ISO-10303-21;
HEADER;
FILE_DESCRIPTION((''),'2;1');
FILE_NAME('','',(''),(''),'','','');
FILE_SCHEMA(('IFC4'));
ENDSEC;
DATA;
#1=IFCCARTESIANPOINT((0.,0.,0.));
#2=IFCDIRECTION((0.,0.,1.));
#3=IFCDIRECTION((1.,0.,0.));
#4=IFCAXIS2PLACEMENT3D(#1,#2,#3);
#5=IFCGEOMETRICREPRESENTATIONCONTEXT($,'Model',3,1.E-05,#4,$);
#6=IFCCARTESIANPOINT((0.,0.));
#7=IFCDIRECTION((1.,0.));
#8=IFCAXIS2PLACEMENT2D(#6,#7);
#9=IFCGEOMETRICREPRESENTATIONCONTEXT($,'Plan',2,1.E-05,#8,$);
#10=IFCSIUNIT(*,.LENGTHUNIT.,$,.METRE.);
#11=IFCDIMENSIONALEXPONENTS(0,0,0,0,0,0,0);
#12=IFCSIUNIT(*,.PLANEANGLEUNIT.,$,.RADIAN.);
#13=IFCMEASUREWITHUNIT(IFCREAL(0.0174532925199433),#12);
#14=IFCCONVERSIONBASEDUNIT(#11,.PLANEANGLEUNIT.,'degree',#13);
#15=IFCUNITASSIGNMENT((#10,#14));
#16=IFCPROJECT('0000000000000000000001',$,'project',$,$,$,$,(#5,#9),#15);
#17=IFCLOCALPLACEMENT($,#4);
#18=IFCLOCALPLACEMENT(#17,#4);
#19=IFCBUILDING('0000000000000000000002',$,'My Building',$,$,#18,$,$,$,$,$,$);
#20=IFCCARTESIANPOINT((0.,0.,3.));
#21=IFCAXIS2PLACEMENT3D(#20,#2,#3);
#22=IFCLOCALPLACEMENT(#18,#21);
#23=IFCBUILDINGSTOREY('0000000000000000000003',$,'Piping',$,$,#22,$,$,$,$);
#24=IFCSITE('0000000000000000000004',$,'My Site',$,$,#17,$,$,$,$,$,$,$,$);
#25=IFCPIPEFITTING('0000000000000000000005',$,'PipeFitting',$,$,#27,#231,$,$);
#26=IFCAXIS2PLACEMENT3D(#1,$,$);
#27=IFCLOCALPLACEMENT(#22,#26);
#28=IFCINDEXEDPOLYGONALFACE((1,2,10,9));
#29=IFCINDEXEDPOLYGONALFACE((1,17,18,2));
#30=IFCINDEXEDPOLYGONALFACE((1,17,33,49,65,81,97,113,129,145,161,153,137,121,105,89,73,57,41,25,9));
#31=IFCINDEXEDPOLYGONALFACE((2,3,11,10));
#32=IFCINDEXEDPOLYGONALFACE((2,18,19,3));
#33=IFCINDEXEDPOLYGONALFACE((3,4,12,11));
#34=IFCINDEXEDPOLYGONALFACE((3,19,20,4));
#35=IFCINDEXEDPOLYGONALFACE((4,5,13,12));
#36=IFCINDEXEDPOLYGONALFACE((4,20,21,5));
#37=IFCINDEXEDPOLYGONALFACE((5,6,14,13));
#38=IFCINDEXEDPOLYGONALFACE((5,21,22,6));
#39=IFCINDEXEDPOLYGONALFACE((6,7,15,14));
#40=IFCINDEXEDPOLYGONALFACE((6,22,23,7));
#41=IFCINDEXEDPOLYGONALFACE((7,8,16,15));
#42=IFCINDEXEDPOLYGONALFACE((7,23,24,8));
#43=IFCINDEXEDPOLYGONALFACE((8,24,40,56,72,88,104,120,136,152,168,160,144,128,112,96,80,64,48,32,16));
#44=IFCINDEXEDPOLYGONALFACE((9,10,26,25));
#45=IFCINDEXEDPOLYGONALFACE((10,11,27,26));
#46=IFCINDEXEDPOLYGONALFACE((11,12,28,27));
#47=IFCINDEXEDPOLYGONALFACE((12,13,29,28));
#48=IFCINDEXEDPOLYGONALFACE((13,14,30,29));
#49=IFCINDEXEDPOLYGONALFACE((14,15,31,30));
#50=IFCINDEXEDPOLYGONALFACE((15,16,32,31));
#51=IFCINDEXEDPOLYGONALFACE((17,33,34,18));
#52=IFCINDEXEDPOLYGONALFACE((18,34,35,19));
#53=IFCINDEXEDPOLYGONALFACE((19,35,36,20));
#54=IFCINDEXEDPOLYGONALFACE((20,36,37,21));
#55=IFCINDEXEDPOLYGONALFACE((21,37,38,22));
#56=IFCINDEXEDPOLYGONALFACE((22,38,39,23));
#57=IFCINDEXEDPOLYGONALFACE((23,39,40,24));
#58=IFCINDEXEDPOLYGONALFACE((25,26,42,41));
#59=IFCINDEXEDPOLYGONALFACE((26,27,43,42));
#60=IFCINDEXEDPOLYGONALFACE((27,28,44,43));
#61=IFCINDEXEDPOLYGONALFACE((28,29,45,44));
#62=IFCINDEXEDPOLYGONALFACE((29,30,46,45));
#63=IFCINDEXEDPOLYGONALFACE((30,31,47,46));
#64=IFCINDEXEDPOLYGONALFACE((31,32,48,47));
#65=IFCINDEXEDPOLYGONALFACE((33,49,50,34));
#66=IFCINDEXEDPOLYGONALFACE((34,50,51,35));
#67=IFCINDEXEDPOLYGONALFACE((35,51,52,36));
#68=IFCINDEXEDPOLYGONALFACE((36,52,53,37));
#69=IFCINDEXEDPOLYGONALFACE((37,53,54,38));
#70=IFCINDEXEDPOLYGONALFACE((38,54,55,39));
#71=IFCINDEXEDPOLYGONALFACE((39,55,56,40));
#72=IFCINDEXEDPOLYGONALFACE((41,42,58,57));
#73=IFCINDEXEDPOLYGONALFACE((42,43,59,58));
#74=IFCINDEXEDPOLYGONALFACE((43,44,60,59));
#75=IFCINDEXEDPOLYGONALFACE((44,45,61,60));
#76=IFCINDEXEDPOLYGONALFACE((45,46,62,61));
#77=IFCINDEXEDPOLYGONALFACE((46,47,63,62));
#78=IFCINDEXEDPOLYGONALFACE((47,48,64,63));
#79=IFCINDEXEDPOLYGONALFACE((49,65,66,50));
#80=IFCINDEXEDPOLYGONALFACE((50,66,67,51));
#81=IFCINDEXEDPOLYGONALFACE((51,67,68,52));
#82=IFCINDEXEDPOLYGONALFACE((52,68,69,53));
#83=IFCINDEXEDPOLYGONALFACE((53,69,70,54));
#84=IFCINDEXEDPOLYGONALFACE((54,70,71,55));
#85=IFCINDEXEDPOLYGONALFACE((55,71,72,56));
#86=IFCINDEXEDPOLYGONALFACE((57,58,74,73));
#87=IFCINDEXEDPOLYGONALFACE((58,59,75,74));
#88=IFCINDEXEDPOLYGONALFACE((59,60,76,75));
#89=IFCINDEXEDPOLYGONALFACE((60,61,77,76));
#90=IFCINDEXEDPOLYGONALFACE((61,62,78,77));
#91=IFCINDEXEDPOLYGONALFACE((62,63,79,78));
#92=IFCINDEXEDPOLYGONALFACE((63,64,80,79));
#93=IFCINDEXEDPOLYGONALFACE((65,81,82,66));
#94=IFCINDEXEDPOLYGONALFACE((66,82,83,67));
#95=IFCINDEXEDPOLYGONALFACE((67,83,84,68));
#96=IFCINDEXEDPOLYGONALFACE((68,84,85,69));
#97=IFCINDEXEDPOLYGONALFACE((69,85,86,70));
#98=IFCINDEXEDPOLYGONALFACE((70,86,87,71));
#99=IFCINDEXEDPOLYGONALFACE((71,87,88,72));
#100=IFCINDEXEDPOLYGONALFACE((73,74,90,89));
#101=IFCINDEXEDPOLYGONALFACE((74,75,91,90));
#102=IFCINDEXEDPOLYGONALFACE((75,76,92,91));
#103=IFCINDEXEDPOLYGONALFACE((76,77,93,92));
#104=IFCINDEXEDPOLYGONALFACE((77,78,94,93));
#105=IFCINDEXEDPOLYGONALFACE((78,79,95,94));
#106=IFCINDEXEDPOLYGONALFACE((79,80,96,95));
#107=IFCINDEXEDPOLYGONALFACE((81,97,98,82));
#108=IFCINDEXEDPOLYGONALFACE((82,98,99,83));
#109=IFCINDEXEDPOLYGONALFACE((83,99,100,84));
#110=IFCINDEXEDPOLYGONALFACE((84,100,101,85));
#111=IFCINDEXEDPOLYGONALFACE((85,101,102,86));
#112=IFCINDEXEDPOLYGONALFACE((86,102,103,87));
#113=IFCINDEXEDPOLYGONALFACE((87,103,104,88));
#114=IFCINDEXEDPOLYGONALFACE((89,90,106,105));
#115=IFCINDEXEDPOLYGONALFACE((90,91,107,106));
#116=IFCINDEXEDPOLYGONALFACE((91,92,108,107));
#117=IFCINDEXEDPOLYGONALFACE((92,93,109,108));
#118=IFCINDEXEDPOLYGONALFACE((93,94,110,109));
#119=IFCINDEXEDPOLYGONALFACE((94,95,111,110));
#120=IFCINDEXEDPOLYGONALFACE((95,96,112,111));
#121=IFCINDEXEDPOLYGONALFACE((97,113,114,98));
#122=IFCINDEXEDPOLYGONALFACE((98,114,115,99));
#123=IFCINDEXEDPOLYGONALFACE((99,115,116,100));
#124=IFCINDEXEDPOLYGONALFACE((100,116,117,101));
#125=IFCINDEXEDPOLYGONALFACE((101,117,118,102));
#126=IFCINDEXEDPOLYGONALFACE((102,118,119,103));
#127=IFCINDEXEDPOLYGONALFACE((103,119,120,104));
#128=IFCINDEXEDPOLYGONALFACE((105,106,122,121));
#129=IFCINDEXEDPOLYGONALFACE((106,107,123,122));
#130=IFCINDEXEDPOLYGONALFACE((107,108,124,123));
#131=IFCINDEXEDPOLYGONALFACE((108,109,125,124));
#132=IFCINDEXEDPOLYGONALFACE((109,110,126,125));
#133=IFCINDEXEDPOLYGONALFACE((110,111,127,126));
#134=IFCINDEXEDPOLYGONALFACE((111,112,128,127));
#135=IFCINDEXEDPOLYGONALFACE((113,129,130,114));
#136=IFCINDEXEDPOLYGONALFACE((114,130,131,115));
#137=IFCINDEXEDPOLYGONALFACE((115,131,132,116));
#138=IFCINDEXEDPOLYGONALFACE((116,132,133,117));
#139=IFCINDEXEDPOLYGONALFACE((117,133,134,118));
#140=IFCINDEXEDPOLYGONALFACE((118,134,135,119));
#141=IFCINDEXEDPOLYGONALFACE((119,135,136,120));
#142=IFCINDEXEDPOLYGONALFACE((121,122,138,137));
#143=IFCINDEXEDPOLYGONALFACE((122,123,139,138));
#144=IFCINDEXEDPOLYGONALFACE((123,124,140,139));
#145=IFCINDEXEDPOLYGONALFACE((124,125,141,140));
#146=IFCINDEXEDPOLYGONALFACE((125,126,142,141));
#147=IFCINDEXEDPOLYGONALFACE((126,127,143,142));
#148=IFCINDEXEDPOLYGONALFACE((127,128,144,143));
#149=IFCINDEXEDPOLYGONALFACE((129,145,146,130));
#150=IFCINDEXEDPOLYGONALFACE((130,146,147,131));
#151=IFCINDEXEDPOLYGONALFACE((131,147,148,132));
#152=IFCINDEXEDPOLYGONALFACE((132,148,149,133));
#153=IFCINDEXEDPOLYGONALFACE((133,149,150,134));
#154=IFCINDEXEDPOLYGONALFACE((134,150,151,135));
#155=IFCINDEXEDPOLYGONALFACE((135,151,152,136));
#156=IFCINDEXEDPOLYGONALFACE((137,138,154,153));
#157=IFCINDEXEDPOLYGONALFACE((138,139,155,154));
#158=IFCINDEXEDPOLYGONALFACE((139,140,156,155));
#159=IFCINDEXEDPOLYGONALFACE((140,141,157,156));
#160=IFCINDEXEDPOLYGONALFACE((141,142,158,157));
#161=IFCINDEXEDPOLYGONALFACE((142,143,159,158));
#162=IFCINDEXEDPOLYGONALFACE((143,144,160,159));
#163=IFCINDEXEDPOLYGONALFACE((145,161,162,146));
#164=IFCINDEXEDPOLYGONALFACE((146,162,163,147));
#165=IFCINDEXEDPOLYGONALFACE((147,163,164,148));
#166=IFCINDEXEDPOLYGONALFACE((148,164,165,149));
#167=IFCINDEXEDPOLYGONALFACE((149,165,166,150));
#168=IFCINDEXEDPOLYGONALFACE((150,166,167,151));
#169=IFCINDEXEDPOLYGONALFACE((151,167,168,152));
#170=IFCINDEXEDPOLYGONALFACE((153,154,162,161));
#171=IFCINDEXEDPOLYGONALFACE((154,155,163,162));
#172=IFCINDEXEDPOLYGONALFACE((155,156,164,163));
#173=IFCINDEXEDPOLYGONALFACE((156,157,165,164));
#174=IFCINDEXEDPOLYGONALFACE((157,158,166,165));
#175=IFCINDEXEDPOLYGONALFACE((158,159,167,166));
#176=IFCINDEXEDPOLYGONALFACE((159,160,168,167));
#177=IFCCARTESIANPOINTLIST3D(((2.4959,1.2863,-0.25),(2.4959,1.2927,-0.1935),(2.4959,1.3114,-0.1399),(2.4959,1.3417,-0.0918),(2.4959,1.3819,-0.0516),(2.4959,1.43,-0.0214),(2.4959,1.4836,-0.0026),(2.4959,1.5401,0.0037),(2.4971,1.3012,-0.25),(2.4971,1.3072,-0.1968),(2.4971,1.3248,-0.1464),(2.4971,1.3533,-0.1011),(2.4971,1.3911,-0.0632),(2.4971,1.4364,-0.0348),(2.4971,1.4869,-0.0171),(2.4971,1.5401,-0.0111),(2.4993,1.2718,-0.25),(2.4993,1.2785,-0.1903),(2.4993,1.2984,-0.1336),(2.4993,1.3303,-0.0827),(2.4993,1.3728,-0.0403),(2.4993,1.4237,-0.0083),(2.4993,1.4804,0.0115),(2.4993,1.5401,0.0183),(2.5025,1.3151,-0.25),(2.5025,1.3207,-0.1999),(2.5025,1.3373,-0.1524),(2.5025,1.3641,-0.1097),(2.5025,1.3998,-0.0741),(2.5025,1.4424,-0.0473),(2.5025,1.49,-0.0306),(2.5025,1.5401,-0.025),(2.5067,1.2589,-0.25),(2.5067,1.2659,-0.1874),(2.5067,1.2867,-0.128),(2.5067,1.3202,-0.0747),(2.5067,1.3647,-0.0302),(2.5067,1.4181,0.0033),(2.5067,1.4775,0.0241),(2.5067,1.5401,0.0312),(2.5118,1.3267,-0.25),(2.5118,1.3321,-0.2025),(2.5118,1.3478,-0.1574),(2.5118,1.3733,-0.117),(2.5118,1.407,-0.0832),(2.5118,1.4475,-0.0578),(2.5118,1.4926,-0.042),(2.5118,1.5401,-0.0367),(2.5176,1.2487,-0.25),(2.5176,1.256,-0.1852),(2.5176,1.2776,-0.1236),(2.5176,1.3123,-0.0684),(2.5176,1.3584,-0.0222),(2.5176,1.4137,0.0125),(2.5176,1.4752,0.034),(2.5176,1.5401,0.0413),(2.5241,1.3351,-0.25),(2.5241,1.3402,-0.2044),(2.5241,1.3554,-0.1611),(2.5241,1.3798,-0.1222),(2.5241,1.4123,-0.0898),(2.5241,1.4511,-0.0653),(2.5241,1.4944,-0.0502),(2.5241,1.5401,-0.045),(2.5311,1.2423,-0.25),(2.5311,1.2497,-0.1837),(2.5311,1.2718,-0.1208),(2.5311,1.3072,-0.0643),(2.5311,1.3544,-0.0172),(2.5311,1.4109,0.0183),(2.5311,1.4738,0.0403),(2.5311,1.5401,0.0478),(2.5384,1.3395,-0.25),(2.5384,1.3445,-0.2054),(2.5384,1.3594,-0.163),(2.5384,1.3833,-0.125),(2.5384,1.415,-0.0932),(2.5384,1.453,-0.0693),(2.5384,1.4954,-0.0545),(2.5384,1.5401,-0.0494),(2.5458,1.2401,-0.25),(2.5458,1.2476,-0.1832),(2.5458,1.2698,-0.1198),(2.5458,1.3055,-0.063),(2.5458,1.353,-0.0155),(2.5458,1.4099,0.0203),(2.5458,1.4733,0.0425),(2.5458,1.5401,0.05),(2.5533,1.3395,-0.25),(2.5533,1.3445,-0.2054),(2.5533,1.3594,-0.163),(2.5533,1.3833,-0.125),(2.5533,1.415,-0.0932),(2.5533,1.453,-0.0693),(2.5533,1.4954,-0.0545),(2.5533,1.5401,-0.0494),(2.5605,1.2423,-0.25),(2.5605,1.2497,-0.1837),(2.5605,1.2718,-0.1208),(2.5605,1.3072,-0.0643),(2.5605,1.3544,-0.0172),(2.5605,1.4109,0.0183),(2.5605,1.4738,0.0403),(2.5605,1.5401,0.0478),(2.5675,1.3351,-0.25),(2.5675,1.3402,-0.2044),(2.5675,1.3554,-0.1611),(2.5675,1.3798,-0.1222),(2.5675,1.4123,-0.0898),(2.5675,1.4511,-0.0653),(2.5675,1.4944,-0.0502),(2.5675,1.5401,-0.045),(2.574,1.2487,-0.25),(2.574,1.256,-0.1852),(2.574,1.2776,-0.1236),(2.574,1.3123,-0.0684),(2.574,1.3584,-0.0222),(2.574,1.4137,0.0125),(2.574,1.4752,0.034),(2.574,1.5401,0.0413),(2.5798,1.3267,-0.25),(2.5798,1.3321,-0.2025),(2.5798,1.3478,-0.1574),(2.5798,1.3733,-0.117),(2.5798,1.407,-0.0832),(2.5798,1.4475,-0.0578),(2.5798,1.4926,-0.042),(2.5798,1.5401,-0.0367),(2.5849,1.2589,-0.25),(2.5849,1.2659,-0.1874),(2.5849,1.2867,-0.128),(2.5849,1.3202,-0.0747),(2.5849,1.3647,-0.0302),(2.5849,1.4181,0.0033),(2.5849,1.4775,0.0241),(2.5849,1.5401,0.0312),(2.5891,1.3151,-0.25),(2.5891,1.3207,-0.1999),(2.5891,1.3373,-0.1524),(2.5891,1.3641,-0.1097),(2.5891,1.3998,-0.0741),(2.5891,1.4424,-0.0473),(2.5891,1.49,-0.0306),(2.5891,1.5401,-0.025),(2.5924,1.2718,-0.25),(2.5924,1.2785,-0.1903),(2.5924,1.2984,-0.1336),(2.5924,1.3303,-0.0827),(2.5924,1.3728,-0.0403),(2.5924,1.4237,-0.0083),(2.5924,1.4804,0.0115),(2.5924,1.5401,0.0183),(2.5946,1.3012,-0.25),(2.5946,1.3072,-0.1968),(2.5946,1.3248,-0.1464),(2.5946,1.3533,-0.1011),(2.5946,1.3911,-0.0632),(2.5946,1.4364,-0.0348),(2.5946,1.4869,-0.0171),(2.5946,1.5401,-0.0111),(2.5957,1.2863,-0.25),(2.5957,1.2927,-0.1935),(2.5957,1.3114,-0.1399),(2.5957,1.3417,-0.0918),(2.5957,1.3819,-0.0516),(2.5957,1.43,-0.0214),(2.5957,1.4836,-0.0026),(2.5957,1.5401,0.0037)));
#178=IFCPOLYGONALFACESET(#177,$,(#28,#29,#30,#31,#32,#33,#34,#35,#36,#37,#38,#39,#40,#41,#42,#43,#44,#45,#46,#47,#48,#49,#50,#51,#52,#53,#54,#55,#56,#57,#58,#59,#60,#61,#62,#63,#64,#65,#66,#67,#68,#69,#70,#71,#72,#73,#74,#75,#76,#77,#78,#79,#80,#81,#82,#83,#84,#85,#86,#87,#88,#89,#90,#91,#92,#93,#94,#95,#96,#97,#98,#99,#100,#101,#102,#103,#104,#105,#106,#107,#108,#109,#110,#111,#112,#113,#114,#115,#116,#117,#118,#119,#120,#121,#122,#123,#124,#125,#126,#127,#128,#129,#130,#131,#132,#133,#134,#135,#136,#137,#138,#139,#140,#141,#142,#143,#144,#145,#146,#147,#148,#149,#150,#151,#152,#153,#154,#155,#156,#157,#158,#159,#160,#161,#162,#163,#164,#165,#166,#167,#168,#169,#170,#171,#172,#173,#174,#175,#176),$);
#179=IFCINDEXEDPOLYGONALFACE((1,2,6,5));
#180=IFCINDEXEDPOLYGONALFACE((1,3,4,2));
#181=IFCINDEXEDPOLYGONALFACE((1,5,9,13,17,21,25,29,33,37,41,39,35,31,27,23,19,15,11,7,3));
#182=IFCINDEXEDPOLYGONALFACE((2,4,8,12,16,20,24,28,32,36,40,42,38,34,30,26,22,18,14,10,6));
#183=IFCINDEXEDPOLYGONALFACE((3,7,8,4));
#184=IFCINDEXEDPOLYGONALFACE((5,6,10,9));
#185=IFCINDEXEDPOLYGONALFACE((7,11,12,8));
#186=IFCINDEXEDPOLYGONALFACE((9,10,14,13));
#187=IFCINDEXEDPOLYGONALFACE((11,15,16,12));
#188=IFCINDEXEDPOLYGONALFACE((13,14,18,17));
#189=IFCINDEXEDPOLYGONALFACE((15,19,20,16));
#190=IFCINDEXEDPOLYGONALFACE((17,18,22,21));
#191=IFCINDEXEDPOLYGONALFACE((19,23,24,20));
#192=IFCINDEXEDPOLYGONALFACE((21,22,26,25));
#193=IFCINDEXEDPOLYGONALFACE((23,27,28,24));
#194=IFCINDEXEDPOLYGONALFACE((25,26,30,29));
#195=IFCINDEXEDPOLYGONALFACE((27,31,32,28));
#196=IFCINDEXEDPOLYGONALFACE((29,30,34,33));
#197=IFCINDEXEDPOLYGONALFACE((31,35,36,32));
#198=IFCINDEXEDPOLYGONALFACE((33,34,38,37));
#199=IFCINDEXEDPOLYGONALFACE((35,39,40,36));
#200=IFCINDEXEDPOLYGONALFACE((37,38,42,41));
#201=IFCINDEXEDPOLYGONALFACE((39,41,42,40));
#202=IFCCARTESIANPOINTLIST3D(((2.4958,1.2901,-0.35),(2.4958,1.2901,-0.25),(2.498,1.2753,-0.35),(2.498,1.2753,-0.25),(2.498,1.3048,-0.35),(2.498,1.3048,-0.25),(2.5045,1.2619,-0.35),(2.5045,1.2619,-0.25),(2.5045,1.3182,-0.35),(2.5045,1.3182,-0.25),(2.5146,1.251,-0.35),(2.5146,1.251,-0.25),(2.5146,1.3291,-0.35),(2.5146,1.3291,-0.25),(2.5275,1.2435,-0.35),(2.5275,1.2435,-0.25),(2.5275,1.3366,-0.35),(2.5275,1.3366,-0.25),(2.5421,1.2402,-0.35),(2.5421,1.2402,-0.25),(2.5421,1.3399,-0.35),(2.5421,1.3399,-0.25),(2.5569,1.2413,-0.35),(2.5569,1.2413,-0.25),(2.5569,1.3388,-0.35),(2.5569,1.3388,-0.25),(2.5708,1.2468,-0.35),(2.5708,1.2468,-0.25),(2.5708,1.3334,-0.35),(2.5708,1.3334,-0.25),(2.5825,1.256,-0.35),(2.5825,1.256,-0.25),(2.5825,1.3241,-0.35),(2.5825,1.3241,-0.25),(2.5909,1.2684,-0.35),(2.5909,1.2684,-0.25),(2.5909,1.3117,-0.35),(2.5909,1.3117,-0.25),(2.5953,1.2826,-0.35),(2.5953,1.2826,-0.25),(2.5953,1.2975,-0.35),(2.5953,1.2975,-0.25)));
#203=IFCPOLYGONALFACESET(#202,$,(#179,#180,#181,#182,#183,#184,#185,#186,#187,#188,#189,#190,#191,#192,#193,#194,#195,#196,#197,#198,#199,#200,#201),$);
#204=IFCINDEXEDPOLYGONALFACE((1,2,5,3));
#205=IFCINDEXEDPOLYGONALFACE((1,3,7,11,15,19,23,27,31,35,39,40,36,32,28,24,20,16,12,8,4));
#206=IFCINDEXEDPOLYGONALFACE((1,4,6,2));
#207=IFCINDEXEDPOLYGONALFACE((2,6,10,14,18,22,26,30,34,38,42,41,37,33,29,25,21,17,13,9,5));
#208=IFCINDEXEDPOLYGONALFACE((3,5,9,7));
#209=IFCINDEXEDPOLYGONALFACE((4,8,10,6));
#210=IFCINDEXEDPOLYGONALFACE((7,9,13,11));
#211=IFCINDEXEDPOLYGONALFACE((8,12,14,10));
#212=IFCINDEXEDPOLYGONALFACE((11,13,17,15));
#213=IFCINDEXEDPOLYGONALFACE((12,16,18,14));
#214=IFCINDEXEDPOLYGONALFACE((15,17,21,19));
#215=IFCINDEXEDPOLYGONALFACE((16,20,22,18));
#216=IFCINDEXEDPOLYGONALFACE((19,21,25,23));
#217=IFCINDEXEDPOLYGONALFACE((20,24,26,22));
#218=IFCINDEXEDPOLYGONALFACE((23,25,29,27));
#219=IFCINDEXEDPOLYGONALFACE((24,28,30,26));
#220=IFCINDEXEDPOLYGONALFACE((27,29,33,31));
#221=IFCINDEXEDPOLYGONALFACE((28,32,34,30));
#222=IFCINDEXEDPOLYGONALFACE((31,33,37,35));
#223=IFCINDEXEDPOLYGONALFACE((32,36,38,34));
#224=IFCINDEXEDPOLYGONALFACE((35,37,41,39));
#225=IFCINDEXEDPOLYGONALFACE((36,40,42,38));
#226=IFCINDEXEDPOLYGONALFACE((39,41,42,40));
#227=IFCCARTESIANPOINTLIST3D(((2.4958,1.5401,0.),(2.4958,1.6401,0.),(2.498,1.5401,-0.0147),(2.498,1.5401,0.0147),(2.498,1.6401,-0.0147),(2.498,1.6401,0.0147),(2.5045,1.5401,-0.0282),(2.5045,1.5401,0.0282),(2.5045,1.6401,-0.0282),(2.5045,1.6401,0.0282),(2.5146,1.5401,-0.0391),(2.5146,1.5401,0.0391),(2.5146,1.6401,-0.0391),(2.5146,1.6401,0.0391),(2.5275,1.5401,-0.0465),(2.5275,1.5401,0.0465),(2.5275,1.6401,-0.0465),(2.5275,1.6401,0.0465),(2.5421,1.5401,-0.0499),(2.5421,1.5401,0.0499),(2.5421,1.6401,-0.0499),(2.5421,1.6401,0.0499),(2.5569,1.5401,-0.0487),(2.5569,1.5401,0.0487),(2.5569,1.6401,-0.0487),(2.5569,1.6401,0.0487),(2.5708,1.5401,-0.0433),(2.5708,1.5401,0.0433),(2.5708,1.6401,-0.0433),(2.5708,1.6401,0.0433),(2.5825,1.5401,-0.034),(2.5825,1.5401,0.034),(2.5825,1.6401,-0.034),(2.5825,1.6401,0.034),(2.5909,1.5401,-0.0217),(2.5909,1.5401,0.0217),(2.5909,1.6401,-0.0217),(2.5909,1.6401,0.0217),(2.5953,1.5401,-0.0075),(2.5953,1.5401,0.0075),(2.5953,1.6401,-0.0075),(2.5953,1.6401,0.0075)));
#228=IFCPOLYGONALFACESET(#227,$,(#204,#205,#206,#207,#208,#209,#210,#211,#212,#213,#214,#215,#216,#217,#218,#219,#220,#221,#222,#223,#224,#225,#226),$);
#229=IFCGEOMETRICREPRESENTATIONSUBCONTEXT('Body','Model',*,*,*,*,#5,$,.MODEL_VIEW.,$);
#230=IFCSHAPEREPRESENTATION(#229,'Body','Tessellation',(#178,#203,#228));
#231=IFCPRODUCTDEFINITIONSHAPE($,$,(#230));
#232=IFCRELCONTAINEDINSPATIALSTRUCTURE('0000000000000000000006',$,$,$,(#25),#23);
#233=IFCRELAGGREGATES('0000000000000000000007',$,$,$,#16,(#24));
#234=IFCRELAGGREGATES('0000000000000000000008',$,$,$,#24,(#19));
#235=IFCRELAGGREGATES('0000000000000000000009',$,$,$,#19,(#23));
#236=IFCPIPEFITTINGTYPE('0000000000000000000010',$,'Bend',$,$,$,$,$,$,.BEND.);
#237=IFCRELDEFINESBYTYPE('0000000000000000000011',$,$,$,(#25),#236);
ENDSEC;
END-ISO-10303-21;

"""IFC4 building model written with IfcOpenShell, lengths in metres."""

from ifc_helpers import new_model, entity, si_unit, converted_unit, frame, origin_with_axes, origin_2d_with_axis, place, context, subcontext, project, spatial, circle, extrude, source, transform, mapped, type_object, type_shapes, element, save


model = new_model("IFC4")

# Units and contexts
model_context = context("Model", 3, precision=1e-05, world=origin_with_axes())
plan_context = context("Plan", 2, precision=1e-05, world=origin_2d_with_axis())
body_context = subcontext(model_context, "Body", "Model", "MODEL_VIEW")
ifc_project = project(units=[si_unit("LENGTHUNIT", "METRE"), converted_unit("PLANEANGLEUNIT", "degree", entity("IfcReal", 0.0174532925199433), si_unit("PLANEANGLEUNIT", "RADIAN"), dimensions=[0, 0, 0, 0, 0, 0, 0])], contexts=[model_context, plan_context])

# Site, building, storey
site_placement = place(None, origin_with_axes())
site = spatial("IfcSite", under=ifc_project, at=site_placement, Name="My Site")
building_placement = place(site_placement, origin_with_axes())
building = spatial("IfcBuilding", under=site, at=building_placement, Name="My Building")
storey_placement = place(building_placement, frame((0.0, 0.0, 3.0), z_axis=(0.0, 0.0, 1.0), x_axis=(1.0, 0.0, 0.0)))
storey = spatial("IfcBuildingStorey", under=building, at=storey_placement, Name="Piping")

# Pipe fitting
pipe_fitting_type_1 = type_object("IfcPipeFittingType", Name="Bend", PredefinedType="BEND")
shared_shape = source(origin_with_axes(), body_context, "Body", "SolidModel", [
    entity("IfcSweptDiskSolid", entity("IfcIndexedPolyCurve", entity("IfcCartesianPointList3D", [[0.0, 0.0, -0.1], [0.0, 0.0732, -0.2768], [0.0, 0.25, -0.35]]), [entity("IfcArcIndex", [1, 2, 3])]), 0.05),
    extrude(circle(Radius=0.05), origin_with_axes(), (0.0, 0.0, -1.0), 0.1),
    extrude(circle(Radius=0.05), frame((0.0, 0.25, -0.35), z_axis=(0.0, 1.0, 0.0), x_axis=(1.0, 0.0, 0.0)), (0.0, 0.0, 1.0), 0.1),
])
type_shapes(pipe_fitting_type_1, [shared_shape])
for number, where, z_axis, x_axis, name in (
    (1, (2.5458, 1.2901, -0.35), (0.0, 0.0, -1.0), (-1.0, 0.0, 0.0), "PipeFitting"),
):
    element("IfcPipeFitting", number, at=place(storey_placement, frame(where, z_axis=z_axis, x_axis=x_axis)), inside=storey, type_object=pipe_fitting_type_1, Name=name, context=body_context, shape_type="MappedRepresentation", body=[
        mapped(shared_shape, transform((0.0, 0.0, 0.0), x_axis=(1.0, 0.0, 0.0), y_axis=(0.0, 1.0, 0.0), z_axis=(0.0, 0.0, 1.0), scale=1.0)),
    ])

save(model, "model.ifc")
